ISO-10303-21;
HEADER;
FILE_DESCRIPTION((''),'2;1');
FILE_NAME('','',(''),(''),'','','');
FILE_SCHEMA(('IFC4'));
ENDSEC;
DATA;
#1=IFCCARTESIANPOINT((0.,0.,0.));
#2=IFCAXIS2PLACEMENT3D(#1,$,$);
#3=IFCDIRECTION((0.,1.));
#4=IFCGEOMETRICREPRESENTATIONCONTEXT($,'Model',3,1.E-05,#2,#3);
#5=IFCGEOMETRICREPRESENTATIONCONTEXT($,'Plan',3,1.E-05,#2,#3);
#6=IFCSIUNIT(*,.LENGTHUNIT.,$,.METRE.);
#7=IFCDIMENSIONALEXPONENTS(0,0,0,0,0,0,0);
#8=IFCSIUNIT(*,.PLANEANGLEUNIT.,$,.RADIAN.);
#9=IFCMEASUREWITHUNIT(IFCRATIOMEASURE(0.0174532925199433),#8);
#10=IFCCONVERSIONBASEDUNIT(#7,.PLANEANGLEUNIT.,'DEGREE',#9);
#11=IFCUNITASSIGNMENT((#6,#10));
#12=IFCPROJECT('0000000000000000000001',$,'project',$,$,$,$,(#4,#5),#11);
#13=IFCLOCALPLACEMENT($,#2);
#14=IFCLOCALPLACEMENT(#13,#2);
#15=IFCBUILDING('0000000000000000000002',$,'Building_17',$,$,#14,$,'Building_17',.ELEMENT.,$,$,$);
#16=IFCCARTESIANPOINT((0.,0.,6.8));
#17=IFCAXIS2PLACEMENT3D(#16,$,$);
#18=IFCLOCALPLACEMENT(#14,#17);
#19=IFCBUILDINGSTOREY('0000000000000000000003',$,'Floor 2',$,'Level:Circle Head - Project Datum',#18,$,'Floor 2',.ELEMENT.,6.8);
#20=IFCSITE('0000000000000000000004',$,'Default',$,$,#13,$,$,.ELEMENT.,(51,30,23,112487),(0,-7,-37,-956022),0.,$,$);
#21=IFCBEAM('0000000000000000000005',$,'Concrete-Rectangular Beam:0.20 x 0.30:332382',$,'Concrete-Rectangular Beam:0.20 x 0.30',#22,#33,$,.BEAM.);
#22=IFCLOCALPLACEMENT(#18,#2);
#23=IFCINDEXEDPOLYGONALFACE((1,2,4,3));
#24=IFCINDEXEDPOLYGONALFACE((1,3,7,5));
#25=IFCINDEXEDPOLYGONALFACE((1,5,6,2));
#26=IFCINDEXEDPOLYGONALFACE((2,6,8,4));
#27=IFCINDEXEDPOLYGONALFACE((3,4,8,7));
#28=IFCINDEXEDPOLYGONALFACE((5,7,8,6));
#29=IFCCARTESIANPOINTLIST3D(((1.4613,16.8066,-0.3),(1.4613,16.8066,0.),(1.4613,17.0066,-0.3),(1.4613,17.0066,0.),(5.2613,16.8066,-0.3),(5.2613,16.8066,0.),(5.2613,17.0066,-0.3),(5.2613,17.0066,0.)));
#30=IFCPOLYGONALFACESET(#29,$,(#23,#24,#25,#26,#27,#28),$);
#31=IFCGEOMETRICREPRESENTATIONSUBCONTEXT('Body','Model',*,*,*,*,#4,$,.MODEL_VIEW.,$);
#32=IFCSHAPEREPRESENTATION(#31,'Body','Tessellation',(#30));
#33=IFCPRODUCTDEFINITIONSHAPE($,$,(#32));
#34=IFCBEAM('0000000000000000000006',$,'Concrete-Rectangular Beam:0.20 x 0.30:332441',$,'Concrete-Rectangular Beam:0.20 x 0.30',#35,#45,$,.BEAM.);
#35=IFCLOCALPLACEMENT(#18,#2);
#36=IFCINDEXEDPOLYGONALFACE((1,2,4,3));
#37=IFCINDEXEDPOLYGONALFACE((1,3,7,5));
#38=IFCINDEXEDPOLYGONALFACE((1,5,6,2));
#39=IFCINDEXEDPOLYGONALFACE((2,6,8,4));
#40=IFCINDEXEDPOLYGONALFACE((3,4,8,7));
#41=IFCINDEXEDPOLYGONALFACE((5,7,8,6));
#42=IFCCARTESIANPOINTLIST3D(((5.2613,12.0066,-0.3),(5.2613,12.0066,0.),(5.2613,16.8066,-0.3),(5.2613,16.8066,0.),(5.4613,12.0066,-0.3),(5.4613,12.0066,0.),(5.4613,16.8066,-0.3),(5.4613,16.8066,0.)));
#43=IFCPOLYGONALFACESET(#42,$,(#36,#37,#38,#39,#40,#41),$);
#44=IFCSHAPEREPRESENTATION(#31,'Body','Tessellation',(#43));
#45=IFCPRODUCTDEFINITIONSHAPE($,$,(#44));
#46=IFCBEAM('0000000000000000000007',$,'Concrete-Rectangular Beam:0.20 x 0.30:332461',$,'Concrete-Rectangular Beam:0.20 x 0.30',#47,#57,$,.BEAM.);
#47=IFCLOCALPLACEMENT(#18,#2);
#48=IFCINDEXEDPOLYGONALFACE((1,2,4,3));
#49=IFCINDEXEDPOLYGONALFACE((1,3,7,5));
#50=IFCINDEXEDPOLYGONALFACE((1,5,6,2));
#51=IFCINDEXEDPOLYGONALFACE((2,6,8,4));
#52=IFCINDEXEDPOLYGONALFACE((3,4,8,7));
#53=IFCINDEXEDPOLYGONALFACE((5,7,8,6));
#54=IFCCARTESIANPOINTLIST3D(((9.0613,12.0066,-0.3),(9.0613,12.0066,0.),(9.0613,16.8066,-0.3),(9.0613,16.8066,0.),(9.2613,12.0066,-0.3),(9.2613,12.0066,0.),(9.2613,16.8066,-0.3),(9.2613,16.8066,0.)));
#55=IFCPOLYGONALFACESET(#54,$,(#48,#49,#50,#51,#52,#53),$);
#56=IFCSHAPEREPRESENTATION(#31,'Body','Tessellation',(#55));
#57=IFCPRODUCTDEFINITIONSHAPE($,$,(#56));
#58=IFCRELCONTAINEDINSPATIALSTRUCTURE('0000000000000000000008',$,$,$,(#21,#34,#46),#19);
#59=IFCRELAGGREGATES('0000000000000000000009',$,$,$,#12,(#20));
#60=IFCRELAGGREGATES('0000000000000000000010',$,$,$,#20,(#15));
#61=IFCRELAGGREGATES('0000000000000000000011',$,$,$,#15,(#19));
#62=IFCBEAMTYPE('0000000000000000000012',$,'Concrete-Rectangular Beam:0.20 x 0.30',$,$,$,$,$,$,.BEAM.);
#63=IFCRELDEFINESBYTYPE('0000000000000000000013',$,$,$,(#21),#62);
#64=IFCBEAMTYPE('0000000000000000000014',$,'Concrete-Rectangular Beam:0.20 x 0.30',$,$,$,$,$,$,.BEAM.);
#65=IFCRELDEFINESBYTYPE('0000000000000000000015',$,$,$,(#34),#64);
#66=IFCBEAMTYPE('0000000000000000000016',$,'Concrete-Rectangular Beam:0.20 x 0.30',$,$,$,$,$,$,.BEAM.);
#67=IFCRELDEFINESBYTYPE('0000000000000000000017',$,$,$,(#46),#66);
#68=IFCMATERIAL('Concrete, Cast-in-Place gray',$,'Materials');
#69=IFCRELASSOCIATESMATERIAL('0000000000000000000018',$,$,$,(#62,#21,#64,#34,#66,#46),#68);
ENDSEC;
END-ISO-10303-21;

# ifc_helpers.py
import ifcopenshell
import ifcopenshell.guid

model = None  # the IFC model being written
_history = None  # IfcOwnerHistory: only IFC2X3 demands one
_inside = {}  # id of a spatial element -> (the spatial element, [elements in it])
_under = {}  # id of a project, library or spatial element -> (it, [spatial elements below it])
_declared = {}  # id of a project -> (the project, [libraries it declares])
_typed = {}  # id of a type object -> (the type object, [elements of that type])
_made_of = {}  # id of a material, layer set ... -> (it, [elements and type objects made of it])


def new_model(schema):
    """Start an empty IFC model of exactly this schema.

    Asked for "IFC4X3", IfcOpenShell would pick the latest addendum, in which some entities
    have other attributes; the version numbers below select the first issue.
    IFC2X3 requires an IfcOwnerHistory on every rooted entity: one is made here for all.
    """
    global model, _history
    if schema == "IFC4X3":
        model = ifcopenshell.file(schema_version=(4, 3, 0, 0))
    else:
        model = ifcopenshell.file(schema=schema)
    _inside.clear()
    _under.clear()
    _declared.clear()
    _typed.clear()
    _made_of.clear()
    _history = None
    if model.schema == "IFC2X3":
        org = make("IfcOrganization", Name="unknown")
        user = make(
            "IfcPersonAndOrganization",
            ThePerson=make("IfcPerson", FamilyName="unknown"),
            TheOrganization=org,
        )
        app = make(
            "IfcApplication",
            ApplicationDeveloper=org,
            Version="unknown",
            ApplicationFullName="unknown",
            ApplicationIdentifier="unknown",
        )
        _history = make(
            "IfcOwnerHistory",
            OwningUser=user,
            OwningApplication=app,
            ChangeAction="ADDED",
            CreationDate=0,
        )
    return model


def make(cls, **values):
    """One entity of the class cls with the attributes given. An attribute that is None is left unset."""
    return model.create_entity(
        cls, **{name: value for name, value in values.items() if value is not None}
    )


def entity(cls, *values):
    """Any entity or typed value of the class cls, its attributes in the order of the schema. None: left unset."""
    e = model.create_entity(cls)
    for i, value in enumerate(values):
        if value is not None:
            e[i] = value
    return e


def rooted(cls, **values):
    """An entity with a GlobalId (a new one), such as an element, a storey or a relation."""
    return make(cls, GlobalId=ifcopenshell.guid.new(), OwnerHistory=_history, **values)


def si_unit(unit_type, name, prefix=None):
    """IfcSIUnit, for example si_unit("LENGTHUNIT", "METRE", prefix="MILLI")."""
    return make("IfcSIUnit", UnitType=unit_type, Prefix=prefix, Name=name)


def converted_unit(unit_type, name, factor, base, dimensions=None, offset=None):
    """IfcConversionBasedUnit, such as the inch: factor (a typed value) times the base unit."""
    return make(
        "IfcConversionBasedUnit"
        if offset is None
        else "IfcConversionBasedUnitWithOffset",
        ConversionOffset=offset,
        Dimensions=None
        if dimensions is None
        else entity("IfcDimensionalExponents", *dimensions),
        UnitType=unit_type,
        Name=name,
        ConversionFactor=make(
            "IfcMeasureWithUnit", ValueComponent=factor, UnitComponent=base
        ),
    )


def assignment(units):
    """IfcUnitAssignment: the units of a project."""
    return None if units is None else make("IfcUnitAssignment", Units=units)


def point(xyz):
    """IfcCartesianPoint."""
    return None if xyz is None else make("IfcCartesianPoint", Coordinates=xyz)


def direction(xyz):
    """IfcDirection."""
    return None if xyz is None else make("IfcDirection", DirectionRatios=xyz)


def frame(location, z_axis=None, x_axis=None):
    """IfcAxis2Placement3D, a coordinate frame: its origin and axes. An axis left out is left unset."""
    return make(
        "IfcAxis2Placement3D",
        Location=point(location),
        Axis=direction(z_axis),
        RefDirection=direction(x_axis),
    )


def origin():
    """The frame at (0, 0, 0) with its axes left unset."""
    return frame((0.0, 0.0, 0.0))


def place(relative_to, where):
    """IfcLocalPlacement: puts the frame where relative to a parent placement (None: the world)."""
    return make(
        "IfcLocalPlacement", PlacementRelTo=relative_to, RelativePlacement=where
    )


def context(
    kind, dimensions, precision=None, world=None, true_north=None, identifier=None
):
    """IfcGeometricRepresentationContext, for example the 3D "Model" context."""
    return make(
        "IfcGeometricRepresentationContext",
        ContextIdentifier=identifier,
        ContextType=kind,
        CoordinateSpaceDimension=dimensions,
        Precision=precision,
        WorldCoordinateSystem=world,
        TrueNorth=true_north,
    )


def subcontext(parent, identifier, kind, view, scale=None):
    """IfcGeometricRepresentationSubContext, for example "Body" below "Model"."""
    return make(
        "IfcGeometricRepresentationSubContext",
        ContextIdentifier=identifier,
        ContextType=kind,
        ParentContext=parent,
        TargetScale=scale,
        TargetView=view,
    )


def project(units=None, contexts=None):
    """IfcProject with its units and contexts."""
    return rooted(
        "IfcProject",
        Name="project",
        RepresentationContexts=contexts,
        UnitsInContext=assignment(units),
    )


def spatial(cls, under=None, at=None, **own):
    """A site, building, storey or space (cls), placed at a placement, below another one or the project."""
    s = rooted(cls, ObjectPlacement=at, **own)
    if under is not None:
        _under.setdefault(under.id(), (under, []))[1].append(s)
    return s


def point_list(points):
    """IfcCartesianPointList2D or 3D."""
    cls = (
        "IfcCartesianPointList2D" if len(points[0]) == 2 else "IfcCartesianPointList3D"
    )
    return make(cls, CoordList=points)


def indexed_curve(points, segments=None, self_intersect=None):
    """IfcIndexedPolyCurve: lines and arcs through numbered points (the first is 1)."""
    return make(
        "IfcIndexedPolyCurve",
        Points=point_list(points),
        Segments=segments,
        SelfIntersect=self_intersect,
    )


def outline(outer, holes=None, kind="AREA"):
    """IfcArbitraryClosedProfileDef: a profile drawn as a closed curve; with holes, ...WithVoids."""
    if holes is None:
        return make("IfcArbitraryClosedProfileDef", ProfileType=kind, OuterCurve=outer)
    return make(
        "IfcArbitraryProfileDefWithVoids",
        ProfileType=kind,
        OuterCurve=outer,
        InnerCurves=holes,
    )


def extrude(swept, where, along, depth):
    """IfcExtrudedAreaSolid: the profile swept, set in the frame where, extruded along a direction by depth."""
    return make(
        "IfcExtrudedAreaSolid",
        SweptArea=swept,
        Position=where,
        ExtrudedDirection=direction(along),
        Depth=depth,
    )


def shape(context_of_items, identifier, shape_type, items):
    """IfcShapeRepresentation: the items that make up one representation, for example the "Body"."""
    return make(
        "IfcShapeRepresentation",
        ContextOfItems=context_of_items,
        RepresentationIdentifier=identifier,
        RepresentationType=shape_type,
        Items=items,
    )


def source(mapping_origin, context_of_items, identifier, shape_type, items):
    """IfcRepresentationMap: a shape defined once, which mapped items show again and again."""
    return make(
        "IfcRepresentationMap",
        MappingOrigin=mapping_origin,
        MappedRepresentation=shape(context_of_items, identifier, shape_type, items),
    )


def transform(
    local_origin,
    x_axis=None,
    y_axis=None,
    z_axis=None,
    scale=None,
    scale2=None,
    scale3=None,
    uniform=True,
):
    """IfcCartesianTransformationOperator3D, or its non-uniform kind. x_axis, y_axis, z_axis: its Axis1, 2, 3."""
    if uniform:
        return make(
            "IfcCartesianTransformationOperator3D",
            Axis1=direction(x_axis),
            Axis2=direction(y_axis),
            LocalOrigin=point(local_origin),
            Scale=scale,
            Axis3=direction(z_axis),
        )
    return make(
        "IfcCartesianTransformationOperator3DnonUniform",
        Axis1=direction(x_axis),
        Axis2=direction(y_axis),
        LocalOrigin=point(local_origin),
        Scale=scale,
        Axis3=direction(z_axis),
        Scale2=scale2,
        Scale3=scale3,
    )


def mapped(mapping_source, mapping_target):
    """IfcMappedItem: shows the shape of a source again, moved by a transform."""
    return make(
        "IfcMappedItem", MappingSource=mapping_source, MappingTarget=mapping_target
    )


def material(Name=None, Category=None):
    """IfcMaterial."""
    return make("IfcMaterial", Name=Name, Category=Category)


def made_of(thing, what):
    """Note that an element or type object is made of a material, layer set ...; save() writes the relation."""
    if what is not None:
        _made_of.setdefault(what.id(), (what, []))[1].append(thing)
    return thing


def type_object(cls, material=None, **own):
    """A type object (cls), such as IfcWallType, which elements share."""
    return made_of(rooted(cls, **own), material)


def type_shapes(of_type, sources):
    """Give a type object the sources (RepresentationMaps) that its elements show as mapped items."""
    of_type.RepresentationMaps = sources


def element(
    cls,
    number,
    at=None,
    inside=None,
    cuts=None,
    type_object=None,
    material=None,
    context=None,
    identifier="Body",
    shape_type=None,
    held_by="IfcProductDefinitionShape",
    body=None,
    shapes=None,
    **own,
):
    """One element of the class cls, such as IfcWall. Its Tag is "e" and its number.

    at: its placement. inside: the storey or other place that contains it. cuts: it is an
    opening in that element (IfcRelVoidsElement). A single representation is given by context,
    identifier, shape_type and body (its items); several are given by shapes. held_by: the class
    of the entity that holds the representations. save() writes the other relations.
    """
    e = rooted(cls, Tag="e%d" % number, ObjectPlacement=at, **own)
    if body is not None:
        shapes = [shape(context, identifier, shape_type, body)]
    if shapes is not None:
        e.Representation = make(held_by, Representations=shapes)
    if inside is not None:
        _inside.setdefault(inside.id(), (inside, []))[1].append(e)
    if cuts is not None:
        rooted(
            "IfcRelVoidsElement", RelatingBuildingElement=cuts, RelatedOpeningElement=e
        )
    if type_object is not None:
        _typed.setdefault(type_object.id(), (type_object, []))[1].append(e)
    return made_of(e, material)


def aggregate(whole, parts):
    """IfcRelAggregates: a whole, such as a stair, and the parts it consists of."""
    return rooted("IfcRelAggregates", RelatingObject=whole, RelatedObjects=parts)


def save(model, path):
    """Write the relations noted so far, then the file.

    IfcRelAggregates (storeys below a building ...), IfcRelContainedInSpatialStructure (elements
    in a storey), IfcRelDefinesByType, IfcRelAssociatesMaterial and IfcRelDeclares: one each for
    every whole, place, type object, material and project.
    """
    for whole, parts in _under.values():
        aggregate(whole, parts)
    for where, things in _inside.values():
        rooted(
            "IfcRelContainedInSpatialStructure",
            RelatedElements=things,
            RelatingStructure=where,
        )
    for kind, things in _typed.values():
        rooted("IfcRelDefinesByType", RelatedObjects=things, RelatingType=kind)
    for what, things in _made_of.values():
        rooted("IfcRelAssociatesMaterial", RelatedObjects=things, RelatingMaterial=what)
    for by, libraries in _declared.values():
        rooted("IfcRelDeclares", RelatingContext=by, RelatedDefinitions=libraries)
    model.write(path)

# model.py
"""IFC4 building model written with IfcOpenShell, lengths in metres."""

from ifc_helpers import new_model, entity, si_unit, converted_unit, direction, frame, origin, place, context, subcontext, project, spatial, indexed_curve, outline, extrude, source, transform, mapped, material, type_object, type_shapes, element, save


model = new_model("IFC4")

# Units and contexts
model_context = context("Model", 3, precision=1e-05, world=origin(), true_north=direction((0.0, 1.0)))
plan_context = context("Plan", 3, precision=1e-05, world=origin(), true_north=direction((0.0, 1.0)))
body_context = subcontext(model_context, "Body", "Model", "MODEL_VIEW")
ifc_project = project(units=[si_unit("LENGTHUNIT", "METRE"), converted_unit("PLANEANGLEUNIT", "DEGREE", entity("IfcRatioMeasure", 0.0174532925199433), si_unit("PLANEANGLEUNIT", "RADIAN"), dimensions=[0, 0, 0, 0, 0, 0, 0])], contexts=[model_context, plan_context])

# Site, building, storey
site_placement = place(None, origin())
site = spatial("IfcSite", under=ifc_project, at=site_placement, Name="Default", CompositionType="ELEMENT", RefLatitude=(51, 30, 23, 112487), RefLongitude=(0, -7, -37, -956022), RefElevation=0.0)
building_placement = place(site_placement, origin())
building = spatial("IfcBuilding", under=site, at=building_placement, Name="Building_17", LongName="Building_17", CompositionType="ELEMENT")
storey_placement = place(building_placement, frame((0.0, 0.0, 6.8)))
storey = spatial("IfcBuildingStorey", under=building, at=storey_placement, Name="Floor 2", ObjectType="Level:Circle Head - Project Datum", LongName="Floor 2", CompositionType="ELEMENT", Elevation=6.8)

# Beams
ifc_material_1 = material(Name="Concrete, Cast-in-Place gray", Category="Materials")
beam_type_1 = type_object("IfcBeamType", Name="Concrete-Rectangular Beam:0.20 x 0.30", PredefinedType="BEAM", material=ifc_material_1)
shared_shape_1 = source(origin(), body_context, "Body", "SweptSolid", [
    extrude(outline(indexed_curve([(-0.15, -0.1), (0.15, -0.1), (0.15, 0.1), (-0.15, 0.1), (-0.15, -0.1)], self_intersect=False)), frame((5.2613, 16.9066, 6.65), z_axis=(-1.0, 0.0, 0.0), x_axis=(0.0, 0.0, -1.0)), (0.0, 0.0, 1.0), 3.8),
])
type_shapes(beam_type_1, [shared_shape_1])
beam_1_placement = place(storey_placement, frame((0.0, 0.0, -6.8)))
element("IfcBeam", 1, at=beam_1_placement, inside=storey, type_object=beam_type_1, material=ifc_material_1, Name="Concrete-Rectangular Beam:0.20 x 0.30:332382", ObjectType="Concrete-Rectangular Beam:0.20 x 0.30", PredefinedType="BEAM", context=body_context, shape_type="MappedRepresentation", body=[
    mapped(shared_shape_1, transform((0.0, 0.0, 0.0), scale=1.0)),
])
beam_type_2 = type_object("IfcBeamType", Name="Concrete-Rectangular Beam:0.20 x 0.30", PredefinedType="BEAM", material=ifc_material_1)
shared_shape_2 = source(origin(), body_context, "Body", "SweptSolid", [
    extrude(outline(indexed_curve([(-0.1, -0.15), (0.1, -0.15), (0.1, 0.15), (-0.1, 0.15), (-0.1, -0.15)], self_intersect=False)), frame((5.3613, 16.8066, 6.65), z_axis=(0.0, -1.0, 0.0), x_axis=(-1.0, 0.0, 0.0)), (0.0, 0.0, 1.0), 4.8),
])
type_shapes(beam_type_2, [shared_shape_2])
beam_2_placement = place(storey_placement, frame((0.0, 0.0, -6.8)))
element("IfcBeam", 2, at=beam_2_placement, inside=storey, type_object=beam_type_2, material=ifc_material_1, Name="Concrete-Rectangular Beam:0.20 x 0.30:332441", ObjectType="Concrete-Rectangular Beam:0.20 x 0.30", PredefinedType="BEAM", context=body_context, shape_type="MappedRepresentation", body=[
    mapped(shared_shape_2, transform((0.0, 0.0, 0.0), scale=1.0)),
])
beam_type_3 = type_object("IfcBeamType", Name="Concrete-Rectangular Beam:0.20 x 0.30", PredefinedType="BEAM", material=ifc_material_1)
shared_shape_3 = source(origin(), body_context, "Body", "SweptSolid", [
    extrude(outline(indexed_curve([(-0.1, -0.15), (0.1, -0.15), (0.1, 0.15), (-0.1, 0.15), (-0.1, -0.15)], self_intersect=False)), frame((9.1613, 16.8066, 6.65), z_axis=(0.0, -1.0, 0.0), x_axis=(-1.0, 0.0, 0.0)), (0.0, 0.0, 1.0), 4.8),
])
type_shapes(beam_type_3, [shared_shape_3])
beam_3_placement = place(storey_placement, frame((0.0, 0.0, -6.8)))
element("IfcBeam", 3, at=beam_3_placement, inside=storey, type_object=beam_type_3, material=ifc_material_1, Name="Concrete-Rectangular Beam:0.20 x 0.30:332461", ObjectType="Concrete-Rectangular Beam:0.20 x 0.30", PredefinedType="BEAM", context=body_context, shape_type="MappedRepresentation", body=[
    mapped(shared_shape_3, transform((0.0, 0.0, 0.0), scale=1.0)),
])

save(model, "model.ifc")
